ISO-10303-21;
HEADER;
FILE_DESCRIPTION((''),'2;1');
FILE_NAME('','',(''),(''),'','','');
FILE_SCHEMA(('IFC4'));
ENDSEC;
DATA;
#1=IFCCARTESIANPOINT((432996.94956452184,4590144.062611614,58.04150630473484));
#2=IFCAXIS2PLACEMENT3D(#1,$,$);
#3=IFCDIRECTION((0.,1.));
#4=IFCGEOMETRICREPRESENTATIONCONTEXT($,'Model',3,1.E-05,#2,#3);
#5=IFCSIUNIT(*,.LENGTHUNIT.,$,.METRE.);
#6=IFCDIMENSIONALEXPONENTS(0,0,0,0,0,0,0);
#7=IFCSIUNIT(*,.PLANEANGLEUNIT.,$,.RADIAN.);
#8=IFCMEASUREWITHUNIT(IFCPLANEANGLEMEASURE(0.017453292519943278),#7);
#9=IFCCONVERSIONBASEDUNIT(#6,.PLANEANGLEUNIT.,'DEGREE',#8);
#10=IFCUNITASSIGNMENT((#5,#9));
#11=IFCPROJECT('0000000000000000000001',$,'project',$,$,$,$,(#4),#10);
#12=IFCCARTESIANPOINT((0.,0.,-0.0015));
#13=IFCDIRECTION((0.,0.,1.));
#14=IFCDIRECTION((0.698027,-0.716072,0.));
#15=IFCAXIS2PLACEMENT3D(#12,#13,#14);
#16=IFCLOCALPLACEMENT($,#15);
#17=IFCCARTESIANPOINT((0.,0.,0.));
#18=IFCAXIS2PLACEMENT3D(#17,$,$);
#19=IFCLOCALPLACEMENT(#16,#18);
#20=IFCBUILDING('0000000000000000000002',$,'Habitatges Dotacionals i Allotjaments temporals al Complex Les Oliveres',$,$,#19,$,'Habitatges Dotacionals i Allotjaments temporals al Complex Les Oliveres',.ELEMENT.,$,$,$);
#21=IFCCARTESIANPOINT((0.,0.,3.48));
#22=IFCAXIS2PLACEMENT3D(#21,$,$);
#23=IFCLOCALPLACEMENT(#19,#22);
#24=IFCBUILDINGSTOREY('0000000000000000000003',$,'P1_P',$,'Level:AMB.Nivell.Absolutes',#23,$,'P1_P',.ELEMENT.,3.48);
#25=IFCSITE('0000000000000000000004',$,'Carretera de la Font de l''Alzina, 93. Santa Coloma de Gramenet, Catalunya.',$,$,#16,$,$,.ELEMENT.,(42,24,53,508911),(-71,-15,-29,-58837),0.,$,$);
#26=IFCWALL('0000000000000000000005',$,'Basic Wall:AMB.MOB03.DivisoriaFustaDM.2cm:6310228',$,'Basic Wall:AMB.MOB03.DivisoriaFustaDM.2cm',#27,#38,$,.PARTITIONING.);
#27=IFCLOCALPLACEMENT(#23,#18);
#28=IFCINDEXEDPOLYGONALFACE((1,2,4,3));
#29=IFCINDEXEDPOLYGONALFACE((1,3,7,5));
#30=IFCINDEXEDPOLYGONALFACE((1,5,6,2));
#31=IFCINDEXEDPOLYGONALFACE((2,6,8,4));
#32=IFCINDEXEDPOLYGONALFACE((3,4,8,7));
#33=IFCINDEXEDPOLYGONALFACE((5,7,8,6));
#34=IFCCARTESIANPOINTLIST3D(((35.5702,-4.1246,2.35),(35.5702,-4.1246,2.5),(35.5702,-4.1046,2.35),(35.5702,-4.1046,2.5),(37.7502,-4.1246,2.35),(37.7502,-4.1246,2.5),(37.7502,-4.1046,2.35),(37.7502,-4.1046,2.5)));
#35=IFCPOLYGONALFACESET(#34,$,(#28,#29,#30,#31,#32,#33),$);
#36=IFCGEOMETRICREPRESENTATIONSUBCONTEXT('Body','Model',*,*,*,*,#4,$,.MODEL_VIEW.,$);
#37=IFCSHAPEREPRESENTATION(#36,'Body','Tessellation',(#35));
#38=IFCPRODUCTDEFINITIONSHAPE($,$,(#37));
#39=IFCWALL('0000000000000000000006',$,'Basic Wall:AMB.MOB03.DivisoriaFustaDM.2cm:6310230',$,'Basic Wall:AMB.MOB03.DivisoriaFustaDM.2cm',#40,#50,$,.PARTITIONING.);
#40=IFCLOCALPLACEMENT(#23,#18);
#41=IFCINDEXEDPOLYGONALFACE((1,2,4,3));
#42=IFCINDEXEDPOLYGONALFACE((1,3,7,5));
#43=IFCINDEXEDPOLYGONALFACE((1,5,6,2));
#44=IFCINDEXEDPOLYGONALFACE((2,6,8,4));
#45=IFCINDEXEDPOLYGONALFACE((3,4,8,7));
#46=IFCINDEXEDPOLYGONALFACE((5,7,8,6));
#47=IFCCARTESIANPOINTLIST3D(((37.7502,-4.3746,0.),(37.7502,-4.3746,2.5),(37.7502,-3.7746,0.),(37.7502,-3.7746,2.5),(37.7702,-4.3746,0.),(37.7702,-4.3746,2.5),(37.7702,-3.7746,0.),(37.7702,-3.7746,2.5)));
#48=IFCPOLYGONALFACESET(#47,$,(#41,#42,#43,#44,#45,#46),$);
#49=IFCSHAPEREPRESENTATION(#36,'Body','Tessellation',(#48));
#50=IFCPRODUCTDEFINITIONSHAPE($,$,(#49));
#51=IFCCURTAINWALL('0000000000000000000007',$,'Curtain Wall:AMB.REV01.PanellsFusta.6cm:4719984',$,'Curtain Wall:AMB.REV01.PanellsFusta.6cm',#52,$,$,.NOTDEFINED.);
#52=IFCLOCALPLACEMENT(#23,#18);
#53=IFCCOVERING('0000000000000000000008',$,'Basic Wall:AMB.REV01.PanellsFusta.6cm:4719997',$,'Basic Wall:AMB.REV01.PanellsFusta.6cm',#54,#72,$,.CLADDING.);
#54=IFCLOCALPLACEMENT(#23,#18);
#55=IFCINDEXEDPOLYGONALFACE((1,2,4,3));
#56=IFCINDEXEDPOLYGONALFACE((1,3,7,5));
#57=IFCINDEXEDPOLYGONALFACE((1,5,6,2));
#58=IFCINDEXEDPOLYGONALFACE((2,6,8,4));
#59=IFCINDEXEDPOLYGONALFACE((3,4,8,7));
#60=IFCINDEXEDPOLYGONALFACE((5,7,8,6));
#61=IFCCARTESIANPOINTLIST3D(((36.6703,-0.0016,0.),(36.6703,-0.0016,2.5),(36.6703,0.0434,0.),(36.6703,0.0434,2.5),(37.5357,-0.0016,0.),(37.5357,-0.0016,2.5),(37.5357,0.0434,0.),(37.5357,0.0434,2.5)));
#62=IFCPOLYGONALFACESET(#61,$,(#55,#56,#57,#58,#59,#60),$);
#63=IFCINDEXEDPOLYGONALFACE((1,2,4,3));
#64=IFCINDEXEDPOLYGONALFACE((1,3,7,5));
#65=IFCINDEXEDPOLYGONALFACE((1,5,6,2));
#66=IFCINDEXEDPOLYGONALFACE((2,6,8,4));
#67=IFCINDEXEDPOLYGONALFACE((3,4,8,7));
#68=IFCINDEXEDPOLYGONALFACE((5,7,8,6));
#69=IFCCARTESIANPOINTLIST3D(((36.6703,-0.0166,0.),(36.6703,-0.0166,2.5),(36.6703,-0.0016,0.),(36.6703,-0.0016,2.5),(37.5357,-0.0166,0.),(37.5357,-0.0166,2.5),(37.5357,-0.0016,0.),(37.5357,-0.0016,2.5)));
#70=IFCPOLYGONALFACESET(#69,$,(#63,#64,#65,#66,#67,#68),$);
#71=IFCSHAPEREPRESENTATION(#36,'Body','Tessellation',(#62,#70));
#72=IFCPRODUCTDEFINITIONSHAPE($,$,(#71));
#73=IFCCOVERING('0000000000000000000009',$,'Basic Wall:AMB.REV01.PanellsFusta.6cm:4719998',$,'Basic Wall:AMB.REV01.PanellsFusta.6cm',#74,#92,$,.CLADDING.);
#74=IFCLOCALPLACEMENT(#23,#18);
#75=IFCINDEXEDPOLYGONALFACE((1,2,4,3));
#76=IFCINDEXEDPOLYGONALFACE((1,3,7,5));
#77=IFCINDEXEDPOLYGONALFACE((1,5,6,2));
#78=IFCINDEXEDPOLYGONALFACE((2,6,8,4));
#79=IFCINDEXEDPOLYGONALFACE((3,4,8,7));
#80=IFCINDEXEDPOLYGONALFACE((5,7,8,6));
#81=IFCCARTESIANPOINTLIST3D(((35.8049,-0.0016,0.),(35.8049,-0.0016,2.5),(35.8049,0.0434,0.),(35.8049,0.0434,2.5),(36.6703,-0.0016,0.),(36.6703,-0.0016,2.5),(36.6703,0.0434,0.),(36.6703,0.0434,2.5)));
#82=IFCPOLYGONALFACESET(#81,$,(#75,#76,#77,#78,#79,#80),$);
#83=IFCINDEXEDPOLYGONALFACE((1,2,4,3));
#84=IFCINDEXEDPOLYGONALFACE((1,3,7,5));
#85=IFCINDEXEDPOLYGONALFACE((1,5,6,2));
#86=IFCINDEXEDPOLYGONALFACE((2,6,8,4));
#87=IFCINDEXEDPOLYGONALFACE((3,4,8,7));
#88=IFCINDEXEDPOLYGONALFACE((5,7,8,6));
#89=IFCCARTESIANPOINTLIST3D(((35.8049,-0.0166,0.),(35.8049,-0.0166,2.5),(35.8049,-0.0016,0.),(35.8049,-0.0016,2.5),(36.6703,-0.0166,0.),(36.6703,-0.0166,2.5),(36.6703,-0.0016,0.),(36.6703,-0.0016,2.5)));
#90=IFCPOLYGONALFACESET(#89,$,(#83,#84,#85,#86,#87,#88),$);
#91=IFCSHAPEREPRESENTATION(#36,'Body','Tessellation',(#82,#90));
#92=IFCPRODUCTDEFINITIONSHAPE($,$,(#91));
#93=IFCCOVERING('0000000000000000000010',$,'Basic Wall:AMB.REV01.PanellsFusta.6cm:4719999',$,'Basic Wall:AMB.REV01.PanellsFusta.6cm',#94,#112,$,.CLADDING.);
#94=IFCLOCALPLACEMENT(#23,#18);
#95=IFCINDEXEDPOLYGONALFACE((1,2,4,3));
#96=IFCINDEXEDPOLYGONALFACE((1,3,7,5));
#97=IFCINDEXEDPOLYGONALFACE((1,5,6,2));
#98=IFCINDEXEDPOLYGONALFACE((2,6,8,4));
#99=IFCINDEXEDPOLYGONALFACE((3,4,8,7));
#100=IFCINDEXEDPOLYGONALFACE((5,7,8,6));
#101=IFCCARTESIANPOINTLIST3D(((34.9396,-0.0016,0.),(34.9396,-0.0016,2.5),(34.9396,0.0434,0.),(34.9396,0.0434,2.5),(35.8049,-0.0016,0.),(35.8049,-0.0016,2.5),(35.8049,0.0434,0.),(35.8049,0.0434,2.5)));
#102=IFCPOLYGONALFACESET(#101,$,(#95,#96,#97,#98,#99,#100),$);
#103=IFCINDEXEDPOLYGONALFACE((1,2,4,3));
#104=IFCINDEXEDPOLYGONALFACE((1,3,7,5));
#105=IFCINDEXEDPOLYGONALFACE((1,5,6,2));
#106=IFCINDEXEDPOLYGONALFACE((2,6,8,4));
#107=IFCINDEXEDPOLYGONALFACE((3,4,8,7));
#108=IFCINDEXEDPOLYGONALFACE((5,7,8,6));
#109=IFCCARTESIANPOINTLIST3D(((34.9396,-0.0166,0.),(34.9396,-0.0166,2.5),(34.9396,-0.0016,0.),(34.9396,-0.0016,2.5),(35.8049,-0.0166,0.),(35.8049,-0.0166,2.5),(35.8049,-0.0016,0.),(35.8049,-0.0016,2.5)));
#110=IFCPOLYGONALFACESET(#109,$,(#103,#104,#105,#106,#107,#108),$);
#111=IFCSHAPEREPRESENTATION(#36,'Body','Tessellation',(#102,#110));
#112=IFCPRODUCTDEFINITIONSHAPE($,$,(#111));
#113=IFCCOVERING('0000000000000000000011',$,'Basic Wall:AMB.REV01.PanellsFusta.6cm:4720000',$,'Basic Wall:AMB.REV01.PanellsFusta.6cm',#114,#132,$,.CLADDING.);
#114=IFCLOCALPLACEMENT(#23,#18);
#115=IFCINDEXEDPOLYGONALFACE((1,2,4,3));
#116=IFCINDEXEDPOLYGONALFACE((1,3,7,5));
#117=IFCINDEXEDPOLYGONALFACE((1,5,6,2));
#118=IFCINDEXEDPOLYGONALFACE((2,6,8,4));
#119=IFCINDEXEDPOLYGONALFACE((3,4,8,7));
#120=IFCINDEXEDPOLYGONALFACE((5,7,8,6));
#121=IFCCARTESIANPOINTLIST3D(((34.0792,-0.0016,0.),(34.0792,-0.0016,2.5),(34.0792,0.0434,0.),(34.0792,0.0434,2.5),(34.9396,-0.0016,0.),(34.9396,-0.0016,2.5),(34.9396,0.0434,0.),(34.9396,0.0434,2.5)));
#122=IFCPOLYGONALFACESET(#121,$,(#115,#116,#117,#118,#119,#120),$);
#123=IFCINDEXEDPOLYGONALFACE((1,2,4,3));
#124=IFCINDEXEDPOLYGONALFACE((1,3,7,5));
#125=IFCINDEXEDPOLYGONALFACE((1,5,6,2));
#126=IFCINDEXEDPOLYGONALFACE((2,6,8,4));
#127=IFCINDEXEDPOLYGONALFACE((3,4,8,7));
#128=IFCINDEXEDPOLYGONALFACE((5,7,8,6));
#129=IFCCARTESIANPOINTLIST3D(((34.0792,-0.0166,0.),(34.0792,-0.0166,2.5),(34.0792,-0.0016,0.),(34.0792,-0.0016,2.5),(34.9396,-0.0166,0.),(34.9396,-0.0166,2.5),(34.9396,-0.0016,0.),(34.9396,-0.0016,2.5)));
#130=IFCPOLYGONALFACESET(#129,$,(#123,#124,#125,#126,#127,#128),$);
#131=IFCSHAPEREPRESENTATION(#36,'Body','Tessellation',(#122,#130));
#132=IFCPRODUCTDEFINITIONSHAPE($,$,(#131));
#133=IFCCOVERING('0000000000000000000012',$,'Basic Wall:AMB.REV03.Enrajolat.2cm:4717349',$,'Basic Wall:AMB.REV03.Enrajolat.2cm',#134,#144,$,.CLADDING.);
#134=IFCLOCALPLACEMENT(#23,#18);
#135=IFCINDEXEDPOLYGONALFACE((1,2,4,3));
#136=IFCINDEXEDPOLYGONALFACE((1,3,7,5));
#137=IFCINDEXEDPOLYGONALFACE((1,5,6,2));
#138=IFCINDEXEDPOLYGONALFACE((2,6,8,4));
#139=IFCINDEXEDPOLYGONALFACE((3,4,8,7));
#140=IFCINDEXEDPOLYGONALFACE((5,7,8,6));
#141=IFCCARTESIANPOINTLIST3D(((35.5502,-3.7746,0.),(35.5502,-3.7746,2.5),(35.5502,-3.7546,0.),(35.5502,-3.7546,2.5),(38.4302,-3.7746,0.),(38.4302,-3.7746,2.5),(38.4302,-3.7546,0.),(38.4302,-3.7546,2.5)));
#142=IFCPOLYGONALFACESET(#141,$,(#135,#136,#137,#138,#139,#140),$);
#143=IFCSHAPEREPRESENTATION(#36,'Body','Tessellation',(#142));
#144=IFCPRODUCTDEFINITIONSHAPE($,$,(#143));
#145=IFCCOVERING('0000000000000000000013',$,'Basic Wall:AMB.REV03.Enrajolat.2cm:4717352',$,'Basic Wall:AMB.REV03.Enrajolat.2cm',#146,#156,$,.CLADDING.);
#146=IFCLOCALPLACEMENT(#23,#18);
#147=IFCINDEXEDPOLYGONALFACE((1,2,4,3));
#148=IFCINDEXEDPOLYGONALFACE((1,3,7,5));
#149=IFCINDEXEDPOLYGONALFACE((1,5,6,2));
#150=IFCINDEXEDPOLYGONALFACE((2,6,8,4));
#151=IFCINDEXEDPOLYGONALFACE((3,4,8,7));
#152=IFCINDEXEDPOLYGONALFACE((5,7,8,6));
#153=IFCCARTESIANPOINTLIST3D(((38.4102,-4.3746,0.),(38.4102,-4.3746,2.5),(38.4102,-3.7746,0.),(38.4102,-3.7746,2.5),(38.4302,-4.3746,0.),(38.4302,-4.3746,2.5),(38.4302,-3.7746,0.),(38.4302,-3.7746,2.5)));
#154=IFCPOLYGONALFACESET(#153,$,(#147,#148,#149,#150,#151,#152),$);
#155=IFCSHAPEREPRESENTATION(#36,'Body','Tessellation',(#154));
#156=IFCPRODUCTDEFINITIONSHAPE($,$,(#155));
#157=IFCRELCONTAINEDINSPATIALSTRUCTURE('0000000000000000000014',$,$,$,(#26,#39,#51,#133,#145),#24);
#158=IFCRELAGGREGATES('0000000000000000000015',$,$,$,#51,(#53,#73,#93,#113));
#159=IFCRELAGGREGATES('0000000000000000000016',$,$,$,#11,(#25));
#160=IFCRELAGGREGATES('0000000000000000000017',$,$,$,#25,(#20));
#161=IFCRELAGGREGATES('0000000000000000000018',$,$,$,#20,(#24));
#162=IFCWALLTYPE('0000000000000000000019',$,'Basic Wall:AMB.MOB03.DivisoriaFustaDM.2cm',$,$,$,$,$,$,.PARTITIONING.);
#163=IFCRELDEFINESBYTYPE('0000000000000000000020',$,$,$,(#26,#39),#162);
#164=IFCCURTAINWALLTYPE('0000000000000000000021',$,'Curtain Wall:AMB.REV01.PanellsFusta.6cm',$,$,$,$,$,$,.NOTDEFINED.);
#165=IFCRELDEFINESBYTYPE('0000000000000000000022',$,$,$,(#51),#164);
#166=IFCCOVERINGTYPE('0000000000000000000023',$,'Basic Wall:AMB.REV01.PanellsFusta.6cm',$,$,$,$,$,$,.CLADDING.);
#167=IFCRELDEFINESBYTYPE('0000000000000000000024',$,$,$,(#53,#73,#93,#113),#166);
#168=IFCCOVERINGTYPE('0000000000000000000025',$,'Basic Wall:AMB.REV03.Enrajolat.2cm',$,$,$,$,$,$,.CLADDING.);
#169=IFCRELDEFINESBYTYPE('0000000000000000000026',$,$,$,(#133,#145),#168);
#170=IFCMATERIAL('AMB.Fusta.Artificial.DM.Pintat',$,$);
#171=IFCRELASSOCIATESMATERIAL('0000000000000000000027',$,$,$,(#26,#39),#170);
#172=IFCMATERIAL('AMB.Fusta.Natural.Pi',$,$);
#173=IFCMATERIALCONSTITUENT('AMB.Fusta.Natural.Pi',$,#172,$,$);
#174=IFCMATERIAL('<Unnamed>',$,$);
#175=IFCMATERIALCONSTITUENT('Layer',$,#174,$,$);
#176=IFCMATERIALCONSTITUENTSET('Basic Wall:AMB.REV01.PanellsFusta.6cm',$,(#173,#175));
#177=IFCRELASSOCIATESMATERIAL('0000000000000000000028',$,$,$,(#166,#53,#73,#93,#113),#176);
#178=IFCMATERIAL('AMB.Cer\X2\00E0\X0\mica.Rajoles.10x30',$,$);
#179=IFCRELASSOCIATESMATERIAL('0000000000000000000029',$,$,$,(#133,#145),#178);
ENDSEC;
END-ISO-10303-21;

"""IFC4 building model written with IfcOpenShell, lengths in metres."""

from ifc_helpers import new_model, entity, si_unit, converted_unit, direction, frame, origin, place, context, subcontext, project, spatial, indexed_curve, outline, extrude, material, constituent, constituent_set, type_object, element, aggregate, save


model = new_model("IFC4")

# Units and contexts
model_context = context("Model", 3, precision=1e-05, world=frame((432996.94956452184, 4590144.062611614, 58.04150630473484)), true_north=direction((0.0, 1.0)))
body_context = subcontext(model_context, "Body", "Model", "MODEL_VIEW")
ifc_project = project(units=[si_unit("LENGTHUNIT", "METRE"), converted_unit("PLANEANGLEUNIT", "DEGREE", entity("IfcPlaneAngleMeasure", 0.017453292519943278), si_unit("PLANEANGLEUNIT", "RADIAN"), dimensions=[0, 0, 0, 0, 0, 0, 0])], contexts=[model_context])

# Site, building, storey
site_placement = place(None, frame((0.0, 0.0, -0.0015), z_axis=(0.0, 0.0, 1.0), x_axis=(0.698027, -0.716072, 0.0)))
site = spatial("IfcSite", under=ifc_project, at=site_placement, Name="Carretera de la Font de l'Alzina, 93. Santa Coloma de Gramenet, Catalunya.", CompositionType="ELEMENT", RefLatitude=(42, 24, 53, 508911), RefLongitude=(-71, -15, -29, -58837), RefElevation=0.0)
building_placement = place(site_placement, origin())
building = spatial("IfcBuilding", under=site, at=building_placement, Name="Habitatges Dotacionals i Allotjaments temporals al Complex Les Oliveres", LongName="Habitatges Dotacionals i Allotjaments temporals al Complex Les Oliveres", CompositionType="ELEMENT")
storey_placement = place(building_placement, frame((0.0, 0.0, 3.48)))
storey = spatial("IfcBuildingStorey", under=building, at=storey_placement, Name="P1_P", ObjectType="Level:AMB.Nivell.Absolutes", LongName="P1_P", CompositionType="ELEMENT", Elevation=3.48)

# Shared definitions
ifc_material_1 = material(Name="AMB.Fusta.Natural.Pi")

# Walls
ifc_material_2 = material(Name="AMB.Fusta.Artificial.DM.Pintat")
wall_type_1 = type_object("IfcWallType", Name="Basic Wall:AMB.MOB03.DivisoriaFustaDM.2cm", PredefinedType="PARTITIONING")
wall_1_placement = place(storey_placement, frame((37.7502, -4.1146, 2.35), z_axis=(0.0, 0.0, 1.0), x_axis=(-1.0, 0.0, 0.0)))
element("IfcWall", 1, at=wall_1_placement, inside=storey, type_object=wall_type_1, material=ifc_material_2, Name="Basic Wall:AMB.MOB03.DivisoriaFustaDM.2cm:6310228", ObjectType="Basic Wall:AMB.MOB03.DivisoriaFustaDM.2cm", PredefinedType="PARTITIONING", context=body_context, shape_type="SweptSolid", body=[
    extrude(outline(indexed_curve([(2.18, 0.01), (0.0, 0.01), (0.0, -0.01), (2.18, -0.01), (2.18, 0.01)], self_intersect=False)), origin(), (0.0, 0.0, 1.0), 0.15),
])
wall_2_placement = place(storey_placement, frame((37.7602, -3.7746, 0.0), z_axis=(0.0, 0.0, 1.0), x_axis=(0.0, -1.0, 0.0)))
element("IfcWall", 2, at=wall_2_placement, inside=storey, type_object=wall_type_1, material=ifc_material_2, Name="Basic Wall:AMB.MOB03.DivisoriaFustaDM.2cm:6310230", ObjectType="Basic Wall:AMB.MOB03.DivisoriaFustaDM.2cm", PredefinedType="PARTITIONING", context=body_context, shape_type="SweptSolid", body=[
    extrude(outline(indexed_curve([(0.6, 0.01), (0.0, 0.01), (0.0, -0.01), (0.6, -0.01), (0.6, 0.01)], self_intersect=False)), origin(), (0.0, 0.0, 1.0), 2.5),
])

# Curtain wall, coverings
curtain_wall_type = type_object("IfcCurtainWallType", Name="Curtain Wall:AMB.REV01.PanellsFusta.6cm", PredefinedType="NOTDEFINED")
curtain_wall_placement = place(storey_placement, frame((0.0, 0.0, -3.48)))
curtain_wall = element("IfcCurtainWall", 3, at=curtain_wall_placement, inside=storey, type_object=curtain_wall_type, Name="Curtain Wall:AMB.REV01.PanellsFusta.6cm:4719984", ObjectType="Curtain Wall:AMB.REV01.PanellsFusta.6cm", PredefinedType="NOTDEFINED")
ifc_constituent_1 = constituent(ifc_material_1, Name="AMB.Fusta.Natural.Pi")
ifc_material_3 = material(Name="<Unnamed>")
ifc_constituent_2 = constituent(ifc_material_3, Name="Layer")
ifc_constituent_set_1 = constituent_set(constituents=[ifc_constituent_1, ifc_constituent_2], Name="Basic Wall:AMB.REV01.PanellsFusta.6cm")
covering_type_1 = type_object("IfcCoveringType", Name="Basic Wall:AMB.REV01.PanellsFusta.6cm", PredefinedType="CLADDING", material=ifc_constituent_set_1)
covering_1_placement = place(storey_placement, frame((37.5357, 0.0134, 0.0), z_axis=(0.0, 0.0, 1.0), x_axis=(-1.0, 0.0, 0.0)))
covering_1 = element("IfcCovering", 4, at=covering_1_placement, type_object=covering_type_1, material=ifc_constituent_set_1, Name="Basic Wall:AMB.REV01.PanellsFusta.6cm:4719997", ObjectType="Basic Wall:AMB.REV01.PanellsFusta.6cm", PredefinedType="CLADDING", context=body_context, shape_type="SweptSolid", body=[
    extrude(outline(indexed_curve([(-0.0225, -0.4327), (0.0225, -0.4327), (0.0225, 0.4327), (-0.0225, 0.4327), (-0.0225, -0.4327)], self_intersect=False)), frame((0.4327, -0.0075, 0.0), z_axis=(0.0, 0.0, 1.0), x_axis=(0.0, 1.0, 0.0)), (0.0, 0.0, 1.0), 2.5),
    extrude(outline(indexed_curve([(-0.0075, -0.4327), (0.0075, -0.4327), (0.0075, 0.4327), (-0.0075, 0.4327), (-0.0075, -0.4327)], self_intersect=False)), frame((0.4327, 0.0225, 0.0), z_axis=(0.0, 0.0, 1.0), x_axis=(0.0, -1.0, 0.0)), (0.0, 0.0, 1.0), 2.5),
])
covering_2_placement = place(storey_placement, frame((36.6703, 0.0134, 0.0), z_axis=(0.0, 0.0, 1.0), x_axis=(-1.0, 0.0, 0.0)))
covering_2 = element("IfcCovering", 5, at=covering_2_placement, type_object=covering_type_1, material=ifc_constituent_set_1, Name="Basic Wall:AMB.REV01.PanellsFusta.6cm:4719998", ObjectType="Basic Wall:AMB.REV01.PanellsFusta.6cm", PredefinedType="CLADDING", context=body_context, shape_type="SweptSolid", body=[
    extrude(outline(indexed_curve([(-0.0225, -0.4327), (0.0225, -0.4327), (0.0225, 0.4327), (-0.0225, 0.4327), (-0.0225, -0.4327)], self_intersect=False)), frame((0.4327, -0.0075, 0.0), z_axis=(0.0, 0.0, 1.0), x_axis=(0.0, 1.0, 0.0)), (0.0, 0.0, 1.0), 2.5),
    extrude(outline(indexed_curve([(-0.0075, -0.4327), (0.0075, -0.4327), (0.0075, 0.4327), (-0.0075, 0.4327), (-0.0075, -0.4327)], self_intersect=False)), frame((0.4327, 0.0225, 0.0), z_axis=(0.0, 0.0, 1.0), x_axis=(0.0, -1.0, 0.0)), (0.0, 0.0, 1.0), 2.5),
])
covering_3_placement = place(storey_placement, frame((35.8049, 0.0134, 0.0), z_axis=(0.0, 0.0, 1.0), x_axis=(-1.0, 0.0, 0.0)))
covering_3 = element("IfcCovering", 6, at=covering_3_placement, type_object=covering_type_1, material=ifc_constituent_set_1, Name="Basic Wall:AMB.REV01.PanellsFusta.6cm:4719999", ObjectType="Basic Wall:AMB.REV01.PanellsFusta.6cm", PredefinedType="CLADDING", context=body_context, shape_type="SweptSolid", body=[
    extrude(outline(indexed_curve([(-0.0225, -0.4327), (0.0225, -0.4327), (0.0225, 0.4327), (-0.0225, 0.4327), (-0.0225, -0.4327)], self_intersect=False)), frame((0.4327, -0.0075, 0.0), z_axis=(0.0, 0.0, 1.0), x_axis=(0.0, 1.0, 0.0)), (0.0, 0.0, 1.0), 2.5),
    extrude(outline(indexed_curve([(-0.0075, -0.4327), (0.0075, -0.4327), (0.0075, 0.4327), (-0.0075, 0.4327), (-0.0075, -0.4327)], self_intersect=False)), frame((0.4327, 0.0225, 0.0), z_axis=(0.0, 0.0, 1.0), x_axis=(0.0, -1.0, 0.0)), (0.0, 0.0, 1.0), 2.5),
])
covering_4_placement = place(storey_placement, frame((34.9396, 0.0134, 0.0), z_axis=(0.0, 0.0, 1.0), x_axis=(-1.0, 0.0, 0.0)))
covering_4 = element("IfcCovering", 7, at=covering_4_placement, type_object=covering_type_1, material=ifc_constituent_set_1, Name="Basic Wall:AMB.REV01.PanellsFusta.6cm:4720000", ObjectType="Basic Wall:AMB.REV01.PanellsFusta.6cm", PredefinedType="CLADDING", context=body_context, shape_type="SweptSolid", body=[
    extrude(outline(indexed_curve([(-0.0225, -0.4302), (0.0225, -0.4302), (0.0225, 0.4302), (-0.0225, 0.4302), (-0.0225, -0.4302)], self_intersect=False)), frame((0.4302, -0.0075, 0.0), z_axis=(0.0, 0.0, 1.0), x_axis=(0.0, 1.0, 0.0)), (0.0, 0.0, 1.0), 2.5),
    extrude(outline(indexed_curve([(-0.0075, -0.4302), (0.0075, -0.4302), (0.0075, 0.4302), (-0.0075, 0.4302), (-0.0075, -0.4302)], self_intersect=False)), frame((0.4302, 0.0225, 0.0), z_axis=(0.0, 0.0, 1.0), x_axis=(0.0, -1.0, 0.0)), (0.0, 0.0, 1.0), 2.5),
])
aggregate(curtain_wall, [covering_1, covering_2, covering_3, covering_4])

# Coverings
ifc_material_4 = material(Name="AMB.Ceràmica.Rajoles.10x30")
covering_type_2 = type_object("IfcCoveringType", Name="Basic Wall:AMB.REV03.Enrajolat.2cm", PredefinedType="CLADDING")
covering_5_placement = place(storey_placement, frame((38.4302, -3.7646, 0.0), z_axis=(0.0, 0.0, 1.0), x_axis=(-1.0, 0.0, 0.0)))
element("IfcCovering", 8, at=covering_5_placement, inside=storey, type_object=covering_type_2, material=ifc_material_4, Name="Basic Wall:AMB.REV03.Enrajolat.2cm:4717349", ObjectType="Basic Wall:AMB.REV03.Enrajolat.2cm", PredefinedType="CLADDING", context=body_context, shape_type="SweptSolid", body=[
    extrude(outline(indexed_curve([(2.88, 0.01), (0.0, 0.01), (0.0, -0.01), (2.88, -0.01), (2.88, 0.01)], self_intersect=False)), origin(), (0.0, 0.0, 1.0), 2.5),
])
covering_6_placement = place(storey_placement, frame((38.4202, -3.7746, 0.0), z_axis=(0.0, 0.0, 1.0), x_axis=(0.0, -1.0, 0.0)))
element("IfcCovering", 9, at=covering_6_placement, inside=storey, type_object=covering_type_2, material=ifc_material_4, Name="Basic Wall:AMB.REV03.Enrajolat.2cm:4717352", ObjectType="Basic Wall:AMB.REV03.Enrajolat.2cm", PredefinedType="CLADDING", context=body_context, shape_type="SweptSolid", body=[
    extrude(outline(indexed_curve([(0.6, 0.01), (0.0, 0.01), (0.0, -0.01), (0.6, -0.01), (0.6, 0.01)], self_intersect=False)), origin(), (0.0, 0.0, 1.0), 2.5),
])

save(model, "model.ifc")
